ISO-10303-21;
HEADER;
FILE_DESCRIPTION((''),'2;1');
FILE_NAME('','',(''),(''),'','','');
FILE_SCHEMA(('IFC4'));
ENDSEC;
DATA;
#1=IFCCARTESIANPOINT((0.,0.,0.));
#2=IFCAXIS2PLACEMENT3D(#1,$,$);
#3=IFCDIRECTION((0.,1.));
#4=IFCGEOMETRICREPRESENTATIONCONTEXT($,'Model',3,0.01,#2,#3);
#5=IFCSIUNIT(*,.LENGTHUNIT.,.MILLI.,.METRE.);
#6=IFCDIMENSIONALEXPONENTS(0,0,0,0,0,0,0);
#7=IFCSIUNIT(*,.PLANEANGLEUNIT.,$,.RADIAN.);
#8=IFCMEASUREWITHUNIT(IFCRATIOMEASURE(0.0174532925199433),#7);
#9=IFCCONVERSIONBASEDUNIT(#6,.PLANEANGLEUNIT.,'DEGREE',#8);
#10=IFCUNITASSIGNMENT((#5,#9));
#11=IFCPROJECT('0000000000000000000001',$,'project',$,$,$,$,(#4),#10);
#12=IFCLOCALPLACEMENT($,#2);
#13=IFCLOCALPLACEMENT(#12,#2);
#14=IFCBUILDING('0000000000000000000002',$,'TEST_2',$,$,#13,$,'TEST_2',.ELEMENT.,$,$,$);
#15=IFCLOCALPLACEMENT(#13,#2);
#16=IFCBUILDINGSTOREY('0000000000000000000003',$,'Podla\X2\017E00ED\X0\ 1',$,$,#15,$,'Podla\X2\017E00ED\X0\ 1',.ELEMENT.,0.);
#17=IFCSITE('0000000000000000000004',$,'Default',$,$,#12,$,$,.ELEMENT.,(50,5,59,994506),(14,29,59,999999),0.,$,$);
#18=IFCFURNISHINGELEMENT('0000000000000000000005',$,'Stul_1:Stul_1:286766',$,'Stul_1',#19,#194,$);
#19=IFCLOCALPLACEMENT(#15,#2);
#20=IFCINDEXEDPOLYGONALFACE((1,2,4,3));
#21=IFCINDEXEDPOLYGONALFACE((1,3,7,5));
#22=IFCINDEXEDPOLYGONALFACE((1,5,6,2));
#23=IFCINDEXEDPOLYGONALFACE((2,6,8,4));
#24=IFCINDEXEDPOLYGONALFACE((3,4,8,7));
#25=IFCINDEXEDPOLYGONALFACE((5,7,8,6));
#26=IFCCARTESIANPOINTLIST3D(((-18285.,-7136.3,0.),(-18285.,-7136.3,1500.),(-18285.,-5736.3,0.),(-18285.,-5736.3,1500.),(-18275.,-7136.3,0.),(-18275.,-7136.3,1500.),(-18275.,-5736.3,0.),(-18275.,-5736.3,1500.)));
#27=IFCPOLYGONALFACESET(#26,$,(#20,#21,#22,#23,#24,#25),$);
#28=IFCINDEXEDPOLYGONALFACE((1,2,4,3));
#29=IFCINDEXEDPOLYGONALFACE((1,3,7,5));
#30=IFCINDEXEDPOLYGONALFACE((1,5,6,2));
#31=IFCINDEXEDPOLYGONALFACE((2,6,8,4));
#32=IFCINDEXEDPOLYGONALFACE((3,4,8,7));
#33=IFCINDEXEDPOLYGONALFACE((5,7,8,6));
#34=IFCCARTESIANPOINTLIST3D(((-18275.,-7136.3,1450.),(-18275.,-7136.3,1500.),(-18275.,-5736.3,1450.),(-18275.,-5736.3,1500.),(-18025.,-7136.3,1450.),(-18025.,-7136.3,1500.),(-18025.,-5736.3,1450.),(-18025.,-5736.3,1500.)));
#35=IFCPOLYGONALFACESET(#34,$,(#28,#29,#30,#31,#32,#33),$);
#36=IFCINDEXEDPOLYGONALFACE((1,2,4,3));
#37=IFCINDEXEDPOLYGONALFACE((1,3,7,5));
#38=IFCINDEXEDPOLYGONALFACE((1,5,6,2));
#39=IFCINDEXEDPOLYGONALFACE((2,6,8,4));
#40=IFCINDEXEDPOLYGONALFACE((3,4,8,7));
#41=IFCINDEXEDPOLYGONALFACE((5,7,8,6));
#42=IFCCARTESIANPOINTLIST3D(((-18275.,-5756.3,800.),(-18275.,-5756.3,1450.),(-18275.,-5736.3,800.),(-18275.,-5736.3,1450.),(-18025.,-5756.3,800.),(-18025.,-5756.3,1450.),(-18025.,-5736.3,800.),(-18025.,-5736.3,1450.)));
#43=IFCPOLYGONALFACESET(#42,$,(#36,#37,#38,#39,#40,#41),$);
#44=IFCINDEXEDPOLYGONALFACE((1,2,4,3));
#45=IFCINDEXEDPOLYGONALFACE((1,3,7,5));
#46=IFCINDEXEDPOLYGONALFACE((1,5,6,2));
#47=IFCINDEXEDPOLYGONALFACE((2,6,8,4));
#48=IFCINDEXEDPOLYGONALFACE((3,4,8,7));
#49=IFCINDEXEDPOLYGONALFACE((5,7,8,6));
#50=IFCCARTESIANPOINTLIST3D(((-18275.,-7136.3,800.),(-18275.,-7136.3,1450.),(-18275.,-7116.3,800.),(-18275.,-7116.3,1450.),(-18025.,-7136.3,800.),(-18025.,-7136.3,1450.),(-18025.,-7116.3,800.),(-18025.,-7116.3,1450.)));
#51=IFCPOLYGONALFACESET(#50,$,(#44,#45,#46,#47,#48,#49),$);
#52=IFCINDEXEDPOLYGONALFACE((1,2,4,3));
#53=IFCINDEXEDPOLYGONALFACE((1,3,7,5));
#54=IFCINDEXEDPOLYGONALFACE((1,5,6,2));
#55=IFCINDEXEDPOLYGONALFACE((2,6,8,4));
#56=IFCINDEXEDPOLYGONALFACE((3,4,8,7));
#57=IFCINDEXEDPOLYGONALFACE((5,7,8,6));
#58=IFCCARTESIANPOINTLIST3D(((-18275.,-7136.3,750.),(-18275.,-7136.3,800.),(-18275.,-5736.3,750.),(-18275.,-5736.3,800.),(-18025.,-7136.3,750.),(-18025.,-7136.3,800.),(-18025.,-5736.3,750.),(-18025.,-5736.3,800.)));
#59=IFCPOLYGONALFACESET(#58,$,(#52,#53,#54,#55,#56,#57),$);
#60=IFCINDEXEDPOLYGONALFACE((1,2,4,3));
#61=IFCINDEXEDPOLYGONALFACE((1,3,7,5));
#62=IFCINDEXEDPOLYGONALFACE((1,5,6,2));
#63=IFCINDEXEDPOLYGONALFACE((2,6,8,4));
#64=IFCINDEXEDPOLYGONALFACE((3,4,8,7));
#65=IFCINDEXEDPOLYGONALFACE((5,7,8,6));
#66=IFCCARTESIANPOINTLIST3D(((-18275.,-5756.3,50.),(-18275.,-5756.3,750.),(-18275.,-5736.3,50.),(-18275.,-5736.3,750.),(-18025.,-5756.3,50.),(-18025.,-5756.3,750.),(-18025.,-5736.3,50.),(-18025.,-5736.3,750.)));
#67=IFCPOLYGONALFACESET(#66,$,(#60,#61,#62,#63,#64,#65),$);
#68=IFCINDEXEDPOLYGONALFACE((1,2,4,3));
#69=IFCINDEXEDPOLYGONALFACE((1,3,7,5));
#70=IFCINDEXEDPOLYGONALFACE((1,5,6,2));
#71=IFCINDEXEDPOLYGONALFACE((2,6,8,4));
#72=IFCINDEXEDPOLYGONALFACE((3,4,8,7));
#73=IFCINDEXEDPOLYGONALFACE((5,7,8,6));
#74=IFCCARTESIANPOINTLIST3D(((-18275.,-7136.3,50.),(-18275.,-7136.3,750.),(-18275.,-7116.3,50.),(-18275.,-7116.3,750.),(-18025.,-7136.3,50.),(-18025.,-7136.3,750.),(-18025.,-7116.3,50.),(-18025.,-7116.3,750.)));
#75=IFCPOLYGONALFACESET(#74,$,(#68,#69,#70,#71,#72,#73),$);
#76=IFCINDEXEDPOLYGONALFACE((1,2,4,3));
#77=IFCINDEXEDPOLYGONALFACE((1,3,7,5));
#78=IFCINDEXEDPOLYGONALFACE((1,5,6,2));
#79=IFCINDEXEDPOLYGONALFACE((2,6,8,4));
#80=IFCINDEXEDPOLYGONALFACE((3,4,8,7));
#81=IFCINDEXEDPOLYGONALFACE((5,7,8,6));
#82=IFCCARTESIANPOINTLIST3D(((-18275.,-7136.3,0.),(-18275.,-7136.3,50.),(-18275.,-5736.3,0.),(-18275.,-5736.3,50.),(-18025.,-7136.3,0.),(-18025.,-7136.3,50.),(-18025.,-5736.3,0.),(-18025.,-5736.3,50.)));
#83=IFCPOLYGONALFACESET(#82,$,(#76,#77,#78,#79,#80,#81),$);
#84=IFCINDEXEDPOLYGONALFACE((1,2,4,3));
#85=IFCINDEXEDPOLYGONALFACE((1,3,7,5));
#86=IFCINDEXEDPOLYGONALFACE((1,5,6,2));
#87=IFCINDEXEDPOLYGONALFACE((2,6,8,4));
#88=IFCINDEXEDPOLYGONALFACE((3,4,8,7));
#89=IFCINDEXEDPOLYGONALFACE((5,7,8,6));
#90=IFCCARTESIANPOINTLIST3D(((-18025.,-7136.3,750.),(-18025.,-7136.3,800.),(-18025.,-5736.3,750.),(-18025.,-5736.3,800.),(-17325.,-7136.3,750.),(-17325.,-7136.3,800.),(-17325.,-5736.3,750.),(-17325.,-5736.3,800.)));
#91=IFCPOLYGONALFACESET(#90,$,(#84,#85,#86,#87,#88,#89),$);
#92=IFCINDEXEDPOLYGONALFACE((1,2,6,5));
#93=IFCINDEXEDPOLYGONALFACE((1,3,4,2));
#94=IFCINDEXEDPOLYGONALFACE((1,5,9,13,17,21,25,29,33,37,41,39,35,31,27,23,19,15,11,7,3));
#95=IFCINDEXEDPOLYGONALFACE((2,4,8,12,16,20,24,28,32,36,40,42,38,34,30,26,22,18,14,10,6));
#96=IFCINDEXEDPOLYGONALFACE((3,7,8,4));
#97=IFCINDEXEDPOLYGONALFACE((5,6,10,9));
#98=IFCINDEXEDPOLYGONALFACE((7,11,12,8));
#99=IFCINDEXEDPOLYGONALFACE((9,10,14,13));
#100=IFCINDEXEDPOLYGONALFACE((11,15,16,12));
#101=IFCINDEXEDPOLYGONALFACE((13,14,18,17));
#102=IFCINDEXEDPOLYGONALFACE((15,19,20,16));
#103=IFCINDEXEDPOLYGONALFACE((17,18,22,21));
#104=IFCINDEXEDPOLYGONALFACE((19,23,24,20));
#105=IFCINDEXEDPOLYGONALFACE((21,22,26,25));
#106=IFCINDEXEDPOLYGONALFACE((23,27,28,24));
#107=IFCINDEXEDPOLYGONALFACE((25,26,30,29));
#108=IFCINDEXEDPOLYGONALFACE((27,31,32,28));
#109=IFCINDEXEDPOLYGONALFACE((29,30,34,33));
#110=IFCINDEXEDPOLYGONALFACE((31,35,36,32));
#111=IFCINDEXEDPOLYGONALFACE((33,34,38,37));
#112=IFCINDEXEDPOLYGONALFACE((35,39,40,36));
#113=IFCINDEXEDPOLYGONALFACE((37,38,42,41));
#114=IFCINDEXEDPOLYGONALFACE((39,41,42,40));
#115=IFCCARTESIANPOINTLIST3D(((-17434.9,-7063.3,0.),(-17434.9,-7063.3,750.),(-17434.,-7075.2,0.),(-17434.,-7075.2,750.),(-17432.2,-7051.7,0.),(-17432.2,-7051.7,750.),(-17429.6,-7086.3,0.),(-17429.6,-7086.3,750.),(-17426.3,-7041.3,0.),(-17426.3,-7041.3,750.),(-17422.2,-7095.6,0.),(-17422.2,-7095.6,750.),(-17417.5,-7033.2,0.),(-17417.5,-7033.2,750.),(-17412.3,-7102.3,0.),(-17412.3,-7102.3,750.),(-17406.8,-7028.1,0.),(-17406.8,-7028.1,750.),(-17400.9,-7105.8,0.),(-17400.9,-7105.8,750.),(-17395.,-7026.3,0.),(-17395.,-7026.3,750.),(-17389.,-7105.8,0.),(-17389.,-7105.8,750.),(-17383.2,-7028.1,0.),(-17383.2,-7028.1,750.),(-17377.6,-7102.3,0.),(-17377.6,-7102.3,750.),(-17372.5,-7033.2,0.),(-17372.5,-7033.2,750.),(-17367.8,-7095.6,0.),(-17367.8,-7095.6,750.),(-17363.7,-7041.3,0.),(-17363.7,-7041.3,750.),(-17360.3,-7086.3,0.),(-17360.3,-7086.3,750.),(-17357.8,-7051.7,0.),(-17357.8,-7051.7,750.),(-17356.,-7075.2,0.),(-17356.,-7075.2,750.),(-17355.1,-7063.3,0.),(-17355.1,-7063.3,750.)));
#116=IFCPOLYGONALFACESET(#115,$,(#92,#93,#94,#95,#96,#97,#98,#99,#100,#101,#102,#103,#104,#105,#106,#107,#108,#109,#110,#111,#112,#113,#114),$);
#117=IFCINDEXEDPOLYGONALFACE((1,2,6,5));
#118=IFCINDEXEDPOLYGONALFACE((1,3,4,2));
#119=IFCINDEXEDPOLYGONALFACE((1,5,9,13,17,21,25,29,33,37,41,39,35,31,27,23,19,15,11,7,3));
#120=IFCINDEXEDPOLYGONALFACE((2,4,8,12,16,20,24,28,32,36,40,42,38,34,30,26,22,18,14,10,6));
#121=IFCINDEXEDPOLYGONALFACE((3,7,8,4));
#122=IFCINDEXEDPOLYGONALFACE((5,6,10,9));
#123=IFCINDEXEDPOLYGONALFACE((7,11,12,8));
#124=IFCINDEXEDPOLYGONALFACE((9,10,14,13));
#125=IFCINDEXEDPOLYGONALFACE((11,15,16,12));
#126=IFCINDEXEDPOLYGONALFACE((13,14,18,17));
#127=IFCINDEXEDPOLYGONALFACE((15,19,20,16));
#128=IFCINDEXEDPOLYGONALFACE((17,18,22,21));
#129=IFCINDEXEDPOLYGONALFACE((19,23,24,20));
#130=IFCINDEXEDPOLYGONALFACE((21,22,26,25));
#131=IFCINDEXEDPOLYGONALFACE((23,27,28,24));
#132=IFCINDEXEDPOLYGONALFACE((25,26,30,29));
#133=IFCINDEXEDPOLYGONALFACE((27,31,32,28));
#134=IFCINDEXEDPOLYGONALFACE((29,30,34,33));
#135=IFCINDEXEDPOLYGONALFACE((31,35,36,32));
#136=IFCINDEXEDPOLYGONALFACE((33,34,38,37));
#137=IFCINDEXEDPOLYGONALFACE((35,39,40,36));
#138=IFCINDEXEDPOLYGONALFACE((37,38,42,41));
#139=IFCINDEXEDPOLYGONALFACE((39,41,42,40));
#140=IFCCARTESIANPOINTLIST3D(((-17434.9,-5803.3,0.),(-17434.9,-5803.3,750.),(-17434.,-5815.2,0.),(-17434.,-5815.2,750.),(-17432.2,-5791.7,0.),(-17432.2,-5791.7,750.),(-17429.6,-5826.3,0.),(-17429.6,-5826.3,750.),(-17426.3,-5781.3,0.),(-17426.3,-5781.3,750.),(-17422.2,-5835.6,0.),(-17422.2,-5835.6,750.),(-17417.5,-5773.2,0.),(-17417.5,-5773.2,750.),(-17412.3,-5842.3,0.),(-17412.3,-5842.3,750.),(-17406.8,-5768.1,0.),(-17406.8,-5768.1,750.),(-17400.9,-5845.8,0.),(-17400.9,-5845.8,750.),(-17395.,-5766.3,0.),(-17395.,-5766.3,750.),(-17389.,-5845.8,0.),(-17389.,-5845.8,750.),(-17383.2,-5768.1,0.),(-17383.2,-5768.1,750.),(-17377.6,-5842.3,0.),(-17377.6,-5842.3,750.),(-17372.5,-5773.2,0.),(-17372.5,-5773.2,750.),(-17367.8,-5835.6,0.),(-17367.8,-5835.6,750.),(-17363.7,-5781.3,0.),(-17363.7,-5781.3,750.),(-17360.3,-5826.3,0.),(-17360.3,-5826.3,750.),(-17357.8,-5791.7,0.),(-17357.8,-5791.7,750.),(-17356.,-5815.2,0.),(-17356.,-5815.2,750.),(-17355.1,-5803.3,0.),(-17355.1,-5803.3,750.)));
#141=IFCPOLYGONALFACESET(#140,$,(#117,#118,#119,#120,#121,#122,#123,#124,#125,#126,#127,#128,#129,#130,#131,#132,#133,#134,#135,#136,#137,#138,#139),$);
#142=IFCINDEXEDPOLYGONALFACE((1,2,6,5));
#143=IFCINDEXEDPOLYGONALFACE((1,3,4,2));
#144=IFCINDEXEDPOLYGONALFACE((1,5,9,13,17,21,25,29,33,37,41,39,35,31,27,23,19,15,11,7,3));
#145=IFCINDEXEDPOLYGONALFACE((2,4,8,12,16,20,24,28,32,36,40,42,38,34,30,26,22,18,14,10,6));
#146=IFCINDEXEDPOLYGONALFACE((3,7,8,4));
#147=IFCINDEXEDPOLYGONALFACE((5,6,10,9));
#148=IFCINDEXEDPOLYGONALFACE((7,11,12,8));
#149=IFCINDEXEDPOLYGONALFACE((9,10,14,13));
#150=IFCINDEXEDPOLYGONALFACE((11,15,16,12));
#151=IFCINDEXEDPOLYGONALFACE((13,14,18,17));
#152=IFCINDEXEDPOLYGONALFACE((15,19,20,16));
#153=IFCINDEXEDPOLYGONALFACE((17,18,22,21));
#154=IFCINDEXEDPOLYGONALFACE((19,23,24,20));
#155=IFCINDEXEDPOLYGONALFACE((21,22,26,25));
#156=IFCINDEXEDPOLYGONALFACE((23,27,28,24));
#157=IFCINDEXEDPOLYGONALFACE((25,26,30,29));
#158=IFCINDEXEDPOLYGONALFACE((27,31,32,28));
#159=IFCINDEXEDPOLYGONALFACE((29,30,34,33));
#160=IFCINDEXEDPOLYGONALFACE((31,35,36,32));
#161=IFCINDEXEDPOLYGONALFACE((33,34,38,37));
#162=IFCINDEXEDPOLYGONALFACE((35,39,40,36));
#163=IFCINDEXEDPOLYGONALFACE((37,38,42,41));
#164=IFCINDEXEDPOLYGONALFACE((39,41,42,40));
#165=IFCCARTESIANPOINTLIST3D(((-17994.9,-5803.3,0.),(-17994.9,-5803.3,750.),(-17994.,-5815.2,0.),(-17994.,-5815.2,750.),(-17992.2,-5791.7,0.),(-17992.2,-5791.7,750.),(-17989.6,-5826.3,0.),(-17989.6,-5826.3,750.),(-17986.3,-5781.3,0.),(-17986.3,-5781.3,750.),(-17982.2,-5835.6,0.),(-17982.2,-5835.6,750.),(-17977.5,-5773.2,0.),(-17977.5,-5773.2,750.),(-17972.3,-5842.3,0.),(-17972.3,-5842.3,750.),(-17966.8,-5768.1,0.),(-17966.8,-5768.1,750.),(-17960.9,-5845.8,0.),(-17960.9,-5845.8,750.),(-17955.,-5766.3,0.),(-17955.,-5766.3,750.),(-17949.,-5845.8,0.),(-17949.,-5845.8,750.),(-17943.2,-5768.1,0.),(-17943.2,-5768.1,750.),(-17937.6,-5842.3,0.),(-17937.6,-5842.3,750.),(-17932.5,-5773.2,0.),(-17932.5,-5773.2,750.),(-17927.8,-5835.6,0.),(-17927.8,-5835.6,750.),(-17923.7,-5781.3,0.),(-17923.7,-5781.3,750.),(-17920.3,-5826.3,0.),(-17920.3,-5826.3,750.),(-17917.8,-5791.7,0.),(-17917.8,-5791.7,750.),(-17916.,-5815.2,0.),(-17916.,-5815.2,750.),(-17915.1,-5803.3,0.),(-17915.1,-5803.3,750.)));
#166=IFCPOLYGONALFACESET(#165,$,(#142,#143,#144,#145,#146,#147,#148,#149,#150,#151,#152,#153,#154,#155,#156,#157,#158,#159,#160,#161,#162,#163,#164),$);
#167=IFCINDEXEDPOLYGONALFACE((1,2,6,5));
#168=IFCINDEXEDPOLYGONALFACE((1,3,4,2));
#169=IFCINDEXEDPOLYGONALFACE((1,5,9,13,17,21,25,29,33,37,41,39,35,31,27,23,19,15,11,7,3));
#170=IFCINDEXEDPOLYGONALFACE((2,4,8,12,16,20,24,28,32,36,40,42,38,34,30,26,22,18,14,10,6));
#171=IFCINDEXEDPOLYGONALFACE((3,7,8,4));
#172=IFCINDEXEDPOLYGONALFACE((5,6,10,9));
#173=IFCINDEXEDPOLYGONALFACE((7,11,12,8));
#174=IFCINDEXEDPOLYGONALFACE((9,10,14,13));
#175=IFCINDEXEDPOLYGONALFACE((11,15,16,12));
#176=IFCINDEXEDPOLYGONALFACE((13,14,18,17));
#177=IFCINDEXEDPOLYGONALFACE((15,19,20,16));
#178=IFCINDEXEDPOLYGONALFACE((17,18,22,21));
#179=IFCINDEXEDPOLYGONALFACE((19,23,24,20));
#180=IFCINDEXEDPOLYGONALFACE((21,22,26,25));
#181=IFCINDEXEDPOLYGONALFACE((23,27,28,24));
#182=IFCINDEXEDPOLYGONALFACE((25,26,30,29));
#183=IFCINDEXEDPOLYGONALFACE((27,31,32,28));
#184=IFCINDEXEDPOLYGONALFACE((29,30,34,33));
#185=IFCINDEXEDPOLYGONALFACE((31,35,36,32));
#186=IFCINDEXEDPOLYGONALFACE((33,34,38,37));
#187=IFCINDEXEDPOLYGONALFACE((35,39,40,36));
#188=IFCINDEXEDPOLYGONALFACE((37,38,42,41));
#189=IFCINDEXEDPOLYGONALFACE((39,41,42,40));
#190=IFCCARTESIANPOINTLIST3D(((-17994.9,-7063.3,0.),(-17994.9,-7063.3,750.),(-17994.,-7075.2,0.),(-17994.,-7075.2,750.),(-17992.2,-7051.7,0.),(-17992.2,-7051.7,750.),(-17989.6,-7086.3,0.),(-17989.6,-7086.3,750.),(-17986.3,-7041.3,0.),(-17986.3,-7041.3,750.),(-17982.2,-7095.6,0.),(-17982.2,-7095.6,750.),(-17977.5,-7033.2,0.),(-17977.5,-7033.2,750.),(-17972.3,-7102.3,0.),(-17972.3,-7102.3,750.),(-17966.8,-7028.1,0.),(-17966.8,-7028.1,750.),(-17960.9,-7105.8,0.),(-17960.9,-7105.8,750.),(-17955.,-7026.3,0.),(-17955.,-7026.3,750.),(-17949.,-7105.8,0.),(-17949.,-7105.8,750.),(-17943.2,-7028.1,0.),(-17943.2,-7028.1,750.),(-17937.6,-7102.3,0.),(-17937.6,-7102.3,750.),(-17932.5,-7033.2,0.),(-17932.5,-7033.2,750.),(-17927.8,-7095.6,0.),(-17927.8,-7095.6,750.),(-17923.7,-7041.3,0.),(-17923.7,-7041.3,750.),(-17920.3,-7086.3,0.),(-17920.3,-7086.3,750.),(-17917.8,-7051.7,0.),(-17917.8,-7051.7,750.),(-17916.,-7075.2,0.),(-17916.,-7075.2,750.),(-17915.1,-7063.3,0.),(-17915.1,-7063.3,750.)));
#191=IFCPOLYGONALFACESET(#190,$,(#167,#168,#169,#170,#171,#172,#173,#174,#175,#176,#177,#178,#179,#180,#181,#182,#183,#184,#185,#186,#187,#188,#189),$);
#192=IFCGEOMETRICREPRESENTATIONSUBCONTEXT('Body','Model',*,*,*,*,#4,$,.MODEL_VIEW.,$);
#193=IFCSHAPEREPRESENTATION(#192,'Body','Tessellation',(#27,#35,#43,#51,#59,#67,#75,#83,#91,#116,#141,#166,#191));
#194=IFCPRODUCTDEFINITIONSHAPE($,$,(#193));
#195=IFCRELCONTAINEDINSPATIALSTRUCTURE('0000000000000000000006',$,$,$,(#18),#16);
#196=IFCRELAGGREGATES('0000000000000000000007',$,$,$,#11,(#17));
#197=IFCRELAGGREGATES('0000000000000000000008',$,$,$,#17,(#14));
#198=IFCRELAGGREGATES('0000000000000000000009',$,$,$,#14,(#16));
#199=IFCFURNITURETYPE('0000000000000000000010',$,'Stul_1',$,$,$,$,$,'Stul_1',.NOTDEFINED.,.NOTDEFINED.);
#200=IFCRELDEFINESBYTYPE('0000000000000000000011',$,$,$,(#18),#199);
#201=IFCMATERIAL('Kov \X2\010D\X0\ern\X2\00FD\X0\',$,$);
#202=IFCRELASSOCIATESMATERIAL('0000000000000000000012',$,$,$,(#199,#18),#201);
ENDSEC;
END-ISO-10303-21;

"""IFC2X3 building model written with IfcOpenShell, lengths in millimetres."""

from ifc_helpers import new_model, entity, si_unit, converted_unit, direction, frame, frame_2d, origin, origin_2d_with_axis, place, context, subcontext, project, spatial, rectangle, circle, extrude, source, transform, mapped, material, type_object, type_shapes, element, save


model = new_model("IFC2X3")

# Units and contexts
model_context = context("Model", 3, precision=0.01, world=origin(), true_north=direction((0.0, 1.0)))
body_context = subcontext(model_context, "Body", "Model", "MODEL_VIEW")
ifc_project = project(units=[si_unit("LENGTHUNIT", "METRE", prefix="MILLI"), converted_unit("PLANEANGLEUNIT", "DEGREE", entity("IfcRatioMeasure", 0.0174532925199433), si_unit("PLANEANGLEUNIT", "RADIAN"), dimensions=[0, 0, 0, 0, 0, 0, 0])], contexts=[model_context])

# Site, building, storey
site_placement = place(None, origin())
site = spatial("IfcSite", under=ifc_project, at=site_placement, Name="Default", CompositionType="ELEMENT", RefLatitude=(50, 5, 59, 994506), RefLongitude=(14, 29, 59, 999999), RefElevation=0.0)
building_placement = place(site_placement, origin())
building = spatial("IfcBuilding", under=site, at=building_placement, Name="TEST_2", LongName="TEST_2", CompositionType="ELEMENT")
storey_placement = place(building_placement, origin())
storey = spatial("IfcBuildingStorey", under=building, at=storey_placement, Name="Podlaží 1", LongName="Podlaží 1", CompositionType="ELEMENT", Elevation=0.0)

# Furnishing element
ifc_material_1 = material(Name="Kov černý")
furniture_type = type_object("IfcFurnitureType", Name="Stul_1", ElementType="Stul_1", material=ifc_material_1)
shared_shape_1 = source(origin(), body_context, "Body", "SweptSolid", [
    extrude(rectangle(XDim=1400.0, YDim=10.0, at=origin_2d_with_axis()), frame((0.0, 605.0, 0.0), z_axis=(0.0, 0.0, 1.0), x_axis=(-1.0, 0.0, 0.0)), (0.0, 0.0, 1.0), 1500.0),
    extrude(rectangle(XDim=1400.0, YDim=250.0, at=frame_2d((0.0, 0.0), x_axis=(1.0, 0.0))), frame((0.0, 475.0, 1450.0), z_axis=(0.0, 0.0, 1.0), x_axis=(-1.0, 0.0, 0.0)), (0.0, 0.0, 1.0), 50.0),
    extrude(rectangle(XDim=20.0, YDim=250.0, at=origin_2d_with_axis()), frame((690.0, 475.0, 800.0), z_axis=(0.0, 0.0, 1.0), x_axis=(-1.0, 0.0, 0.0)), (0.0, 0.0, 1.0), 650.0),
    extrude(rectangle(XDim=20.0, YDim=250.0, at=frame_2d((0.0, 0.0), x_axis=(1.0, 0.0))), frame((-690.0, 475.0, 800.0), z_axis=(0.0, 0.0, 1.0), x_axis=(-1.0, 0.0, 0.0)), (0.0, 0.0, 1.0), 650.0),
    extrude(rectangle(XDim=1400.0, YDim=250.0, at=origin_2d_with_axis()), frame((0.0, 475.0, 750.0), z_axis=(0.0, 0.0, 1.0), x_axis=(-1.0, 0.0, 0.0)), (0.0, 0.0, 1.0), 50.0),
    extrude(rectangle(XDim=20.0, YDim=250.0, at=origin_2d_with_axis()), frame((690.0, 475.0, 50.0), z_axis=(0.0, 0.0, 1.0), x_axis=(-1.0, 0.0, 0.0)), (0.0, 0.0, 1.0), 700.0),
    extrude(rectangle(XDim=20.0, YDim=250.0, at=frame_2d((0.0, 0.0), x_axis=(1.0, 0.0))), frame((-690.0, 475.0, 50.0), z_axis=(0.0, 0.0, 1.0), x_axis=(-1.0, 0.0, 0.0)), (0.0, 0.0, 1.0), 700.0),
    extrude(rectangle(XDim=1400.0, YDim=250.0, at=origin_2d_with_axis()), frame((0.0, 475.0, 0.0), z_axis=(0.0, 0.0, 1.0), x_axis=(-1.0, 0.0, 0.0)), (0.0, 0.0, 1.0), 50.0),
    extrude(rectangle(XDim=1400.0, YDim=700.0, at=origin_2d_with_axis()), frame((0.0, 0.0, 750.0), z_axis=(0.0, 0.0, 1.0), x_axis=(-1.0, 0.0, 0.0)), (0.0, 0.0, 1.0), 50.0),
    extrude(circle(Radius=40.0, at=frame_2d((0.0, 0.0), x_axis=(1.0, 0.0))), frame((-630.0, -280.0, 0.0)), (0.0, 0.0, 1.0), 750.0),
    extrude(circle(Radius=40.0, at=frame_2d((0.0, 0.0), x_axis=(1.0, 0.0))), frame((630.0, -280.0, 0.0)), (0.0, 0.0, 1.0), 750.0),
    extrude(circle(Radius=40.0, at=frame_2d((0.0, 0.0), x_axis=(1.0, 0.0))), frame((630.0, 280.0, 0.0)), (0.0, 0.0, 1.0), 750.0),
    extrude(circle(Radius=40.0, at=frame_2d((0.0, 0.0), x_axis=(1.0, 0.0))), frame((-630.0, 280.0, 0.0)), (0.0, 0.0, 1.0), 750.0),
])
type_shapes(furniture_type, [shared_shape_1])
for number, where, z_axis, x_axis, name in (
    (1, (-17675.0, -6436.3, 0.0), (0.0, 0.0, 1.0), (0.0, 1.0, 0.0), "Stul_1:Stul_1:286766"),
):
    element("IfcFurnishingElement", number, at=place(storey_placement, frame(where, z_axis=z_axis, x_axis=x_axis)), inside=storey, type_object=furniture_type, material=ifc_material_1, Name=name, ObjectType="Stul_1", context=body_context, shape_type="MappedRepresentation", body=[
        mapped(shared_shape_1, transform((0.0, 0.0, 0.0), scale=1.0)),
    ])

save(model, "model.ifc")
